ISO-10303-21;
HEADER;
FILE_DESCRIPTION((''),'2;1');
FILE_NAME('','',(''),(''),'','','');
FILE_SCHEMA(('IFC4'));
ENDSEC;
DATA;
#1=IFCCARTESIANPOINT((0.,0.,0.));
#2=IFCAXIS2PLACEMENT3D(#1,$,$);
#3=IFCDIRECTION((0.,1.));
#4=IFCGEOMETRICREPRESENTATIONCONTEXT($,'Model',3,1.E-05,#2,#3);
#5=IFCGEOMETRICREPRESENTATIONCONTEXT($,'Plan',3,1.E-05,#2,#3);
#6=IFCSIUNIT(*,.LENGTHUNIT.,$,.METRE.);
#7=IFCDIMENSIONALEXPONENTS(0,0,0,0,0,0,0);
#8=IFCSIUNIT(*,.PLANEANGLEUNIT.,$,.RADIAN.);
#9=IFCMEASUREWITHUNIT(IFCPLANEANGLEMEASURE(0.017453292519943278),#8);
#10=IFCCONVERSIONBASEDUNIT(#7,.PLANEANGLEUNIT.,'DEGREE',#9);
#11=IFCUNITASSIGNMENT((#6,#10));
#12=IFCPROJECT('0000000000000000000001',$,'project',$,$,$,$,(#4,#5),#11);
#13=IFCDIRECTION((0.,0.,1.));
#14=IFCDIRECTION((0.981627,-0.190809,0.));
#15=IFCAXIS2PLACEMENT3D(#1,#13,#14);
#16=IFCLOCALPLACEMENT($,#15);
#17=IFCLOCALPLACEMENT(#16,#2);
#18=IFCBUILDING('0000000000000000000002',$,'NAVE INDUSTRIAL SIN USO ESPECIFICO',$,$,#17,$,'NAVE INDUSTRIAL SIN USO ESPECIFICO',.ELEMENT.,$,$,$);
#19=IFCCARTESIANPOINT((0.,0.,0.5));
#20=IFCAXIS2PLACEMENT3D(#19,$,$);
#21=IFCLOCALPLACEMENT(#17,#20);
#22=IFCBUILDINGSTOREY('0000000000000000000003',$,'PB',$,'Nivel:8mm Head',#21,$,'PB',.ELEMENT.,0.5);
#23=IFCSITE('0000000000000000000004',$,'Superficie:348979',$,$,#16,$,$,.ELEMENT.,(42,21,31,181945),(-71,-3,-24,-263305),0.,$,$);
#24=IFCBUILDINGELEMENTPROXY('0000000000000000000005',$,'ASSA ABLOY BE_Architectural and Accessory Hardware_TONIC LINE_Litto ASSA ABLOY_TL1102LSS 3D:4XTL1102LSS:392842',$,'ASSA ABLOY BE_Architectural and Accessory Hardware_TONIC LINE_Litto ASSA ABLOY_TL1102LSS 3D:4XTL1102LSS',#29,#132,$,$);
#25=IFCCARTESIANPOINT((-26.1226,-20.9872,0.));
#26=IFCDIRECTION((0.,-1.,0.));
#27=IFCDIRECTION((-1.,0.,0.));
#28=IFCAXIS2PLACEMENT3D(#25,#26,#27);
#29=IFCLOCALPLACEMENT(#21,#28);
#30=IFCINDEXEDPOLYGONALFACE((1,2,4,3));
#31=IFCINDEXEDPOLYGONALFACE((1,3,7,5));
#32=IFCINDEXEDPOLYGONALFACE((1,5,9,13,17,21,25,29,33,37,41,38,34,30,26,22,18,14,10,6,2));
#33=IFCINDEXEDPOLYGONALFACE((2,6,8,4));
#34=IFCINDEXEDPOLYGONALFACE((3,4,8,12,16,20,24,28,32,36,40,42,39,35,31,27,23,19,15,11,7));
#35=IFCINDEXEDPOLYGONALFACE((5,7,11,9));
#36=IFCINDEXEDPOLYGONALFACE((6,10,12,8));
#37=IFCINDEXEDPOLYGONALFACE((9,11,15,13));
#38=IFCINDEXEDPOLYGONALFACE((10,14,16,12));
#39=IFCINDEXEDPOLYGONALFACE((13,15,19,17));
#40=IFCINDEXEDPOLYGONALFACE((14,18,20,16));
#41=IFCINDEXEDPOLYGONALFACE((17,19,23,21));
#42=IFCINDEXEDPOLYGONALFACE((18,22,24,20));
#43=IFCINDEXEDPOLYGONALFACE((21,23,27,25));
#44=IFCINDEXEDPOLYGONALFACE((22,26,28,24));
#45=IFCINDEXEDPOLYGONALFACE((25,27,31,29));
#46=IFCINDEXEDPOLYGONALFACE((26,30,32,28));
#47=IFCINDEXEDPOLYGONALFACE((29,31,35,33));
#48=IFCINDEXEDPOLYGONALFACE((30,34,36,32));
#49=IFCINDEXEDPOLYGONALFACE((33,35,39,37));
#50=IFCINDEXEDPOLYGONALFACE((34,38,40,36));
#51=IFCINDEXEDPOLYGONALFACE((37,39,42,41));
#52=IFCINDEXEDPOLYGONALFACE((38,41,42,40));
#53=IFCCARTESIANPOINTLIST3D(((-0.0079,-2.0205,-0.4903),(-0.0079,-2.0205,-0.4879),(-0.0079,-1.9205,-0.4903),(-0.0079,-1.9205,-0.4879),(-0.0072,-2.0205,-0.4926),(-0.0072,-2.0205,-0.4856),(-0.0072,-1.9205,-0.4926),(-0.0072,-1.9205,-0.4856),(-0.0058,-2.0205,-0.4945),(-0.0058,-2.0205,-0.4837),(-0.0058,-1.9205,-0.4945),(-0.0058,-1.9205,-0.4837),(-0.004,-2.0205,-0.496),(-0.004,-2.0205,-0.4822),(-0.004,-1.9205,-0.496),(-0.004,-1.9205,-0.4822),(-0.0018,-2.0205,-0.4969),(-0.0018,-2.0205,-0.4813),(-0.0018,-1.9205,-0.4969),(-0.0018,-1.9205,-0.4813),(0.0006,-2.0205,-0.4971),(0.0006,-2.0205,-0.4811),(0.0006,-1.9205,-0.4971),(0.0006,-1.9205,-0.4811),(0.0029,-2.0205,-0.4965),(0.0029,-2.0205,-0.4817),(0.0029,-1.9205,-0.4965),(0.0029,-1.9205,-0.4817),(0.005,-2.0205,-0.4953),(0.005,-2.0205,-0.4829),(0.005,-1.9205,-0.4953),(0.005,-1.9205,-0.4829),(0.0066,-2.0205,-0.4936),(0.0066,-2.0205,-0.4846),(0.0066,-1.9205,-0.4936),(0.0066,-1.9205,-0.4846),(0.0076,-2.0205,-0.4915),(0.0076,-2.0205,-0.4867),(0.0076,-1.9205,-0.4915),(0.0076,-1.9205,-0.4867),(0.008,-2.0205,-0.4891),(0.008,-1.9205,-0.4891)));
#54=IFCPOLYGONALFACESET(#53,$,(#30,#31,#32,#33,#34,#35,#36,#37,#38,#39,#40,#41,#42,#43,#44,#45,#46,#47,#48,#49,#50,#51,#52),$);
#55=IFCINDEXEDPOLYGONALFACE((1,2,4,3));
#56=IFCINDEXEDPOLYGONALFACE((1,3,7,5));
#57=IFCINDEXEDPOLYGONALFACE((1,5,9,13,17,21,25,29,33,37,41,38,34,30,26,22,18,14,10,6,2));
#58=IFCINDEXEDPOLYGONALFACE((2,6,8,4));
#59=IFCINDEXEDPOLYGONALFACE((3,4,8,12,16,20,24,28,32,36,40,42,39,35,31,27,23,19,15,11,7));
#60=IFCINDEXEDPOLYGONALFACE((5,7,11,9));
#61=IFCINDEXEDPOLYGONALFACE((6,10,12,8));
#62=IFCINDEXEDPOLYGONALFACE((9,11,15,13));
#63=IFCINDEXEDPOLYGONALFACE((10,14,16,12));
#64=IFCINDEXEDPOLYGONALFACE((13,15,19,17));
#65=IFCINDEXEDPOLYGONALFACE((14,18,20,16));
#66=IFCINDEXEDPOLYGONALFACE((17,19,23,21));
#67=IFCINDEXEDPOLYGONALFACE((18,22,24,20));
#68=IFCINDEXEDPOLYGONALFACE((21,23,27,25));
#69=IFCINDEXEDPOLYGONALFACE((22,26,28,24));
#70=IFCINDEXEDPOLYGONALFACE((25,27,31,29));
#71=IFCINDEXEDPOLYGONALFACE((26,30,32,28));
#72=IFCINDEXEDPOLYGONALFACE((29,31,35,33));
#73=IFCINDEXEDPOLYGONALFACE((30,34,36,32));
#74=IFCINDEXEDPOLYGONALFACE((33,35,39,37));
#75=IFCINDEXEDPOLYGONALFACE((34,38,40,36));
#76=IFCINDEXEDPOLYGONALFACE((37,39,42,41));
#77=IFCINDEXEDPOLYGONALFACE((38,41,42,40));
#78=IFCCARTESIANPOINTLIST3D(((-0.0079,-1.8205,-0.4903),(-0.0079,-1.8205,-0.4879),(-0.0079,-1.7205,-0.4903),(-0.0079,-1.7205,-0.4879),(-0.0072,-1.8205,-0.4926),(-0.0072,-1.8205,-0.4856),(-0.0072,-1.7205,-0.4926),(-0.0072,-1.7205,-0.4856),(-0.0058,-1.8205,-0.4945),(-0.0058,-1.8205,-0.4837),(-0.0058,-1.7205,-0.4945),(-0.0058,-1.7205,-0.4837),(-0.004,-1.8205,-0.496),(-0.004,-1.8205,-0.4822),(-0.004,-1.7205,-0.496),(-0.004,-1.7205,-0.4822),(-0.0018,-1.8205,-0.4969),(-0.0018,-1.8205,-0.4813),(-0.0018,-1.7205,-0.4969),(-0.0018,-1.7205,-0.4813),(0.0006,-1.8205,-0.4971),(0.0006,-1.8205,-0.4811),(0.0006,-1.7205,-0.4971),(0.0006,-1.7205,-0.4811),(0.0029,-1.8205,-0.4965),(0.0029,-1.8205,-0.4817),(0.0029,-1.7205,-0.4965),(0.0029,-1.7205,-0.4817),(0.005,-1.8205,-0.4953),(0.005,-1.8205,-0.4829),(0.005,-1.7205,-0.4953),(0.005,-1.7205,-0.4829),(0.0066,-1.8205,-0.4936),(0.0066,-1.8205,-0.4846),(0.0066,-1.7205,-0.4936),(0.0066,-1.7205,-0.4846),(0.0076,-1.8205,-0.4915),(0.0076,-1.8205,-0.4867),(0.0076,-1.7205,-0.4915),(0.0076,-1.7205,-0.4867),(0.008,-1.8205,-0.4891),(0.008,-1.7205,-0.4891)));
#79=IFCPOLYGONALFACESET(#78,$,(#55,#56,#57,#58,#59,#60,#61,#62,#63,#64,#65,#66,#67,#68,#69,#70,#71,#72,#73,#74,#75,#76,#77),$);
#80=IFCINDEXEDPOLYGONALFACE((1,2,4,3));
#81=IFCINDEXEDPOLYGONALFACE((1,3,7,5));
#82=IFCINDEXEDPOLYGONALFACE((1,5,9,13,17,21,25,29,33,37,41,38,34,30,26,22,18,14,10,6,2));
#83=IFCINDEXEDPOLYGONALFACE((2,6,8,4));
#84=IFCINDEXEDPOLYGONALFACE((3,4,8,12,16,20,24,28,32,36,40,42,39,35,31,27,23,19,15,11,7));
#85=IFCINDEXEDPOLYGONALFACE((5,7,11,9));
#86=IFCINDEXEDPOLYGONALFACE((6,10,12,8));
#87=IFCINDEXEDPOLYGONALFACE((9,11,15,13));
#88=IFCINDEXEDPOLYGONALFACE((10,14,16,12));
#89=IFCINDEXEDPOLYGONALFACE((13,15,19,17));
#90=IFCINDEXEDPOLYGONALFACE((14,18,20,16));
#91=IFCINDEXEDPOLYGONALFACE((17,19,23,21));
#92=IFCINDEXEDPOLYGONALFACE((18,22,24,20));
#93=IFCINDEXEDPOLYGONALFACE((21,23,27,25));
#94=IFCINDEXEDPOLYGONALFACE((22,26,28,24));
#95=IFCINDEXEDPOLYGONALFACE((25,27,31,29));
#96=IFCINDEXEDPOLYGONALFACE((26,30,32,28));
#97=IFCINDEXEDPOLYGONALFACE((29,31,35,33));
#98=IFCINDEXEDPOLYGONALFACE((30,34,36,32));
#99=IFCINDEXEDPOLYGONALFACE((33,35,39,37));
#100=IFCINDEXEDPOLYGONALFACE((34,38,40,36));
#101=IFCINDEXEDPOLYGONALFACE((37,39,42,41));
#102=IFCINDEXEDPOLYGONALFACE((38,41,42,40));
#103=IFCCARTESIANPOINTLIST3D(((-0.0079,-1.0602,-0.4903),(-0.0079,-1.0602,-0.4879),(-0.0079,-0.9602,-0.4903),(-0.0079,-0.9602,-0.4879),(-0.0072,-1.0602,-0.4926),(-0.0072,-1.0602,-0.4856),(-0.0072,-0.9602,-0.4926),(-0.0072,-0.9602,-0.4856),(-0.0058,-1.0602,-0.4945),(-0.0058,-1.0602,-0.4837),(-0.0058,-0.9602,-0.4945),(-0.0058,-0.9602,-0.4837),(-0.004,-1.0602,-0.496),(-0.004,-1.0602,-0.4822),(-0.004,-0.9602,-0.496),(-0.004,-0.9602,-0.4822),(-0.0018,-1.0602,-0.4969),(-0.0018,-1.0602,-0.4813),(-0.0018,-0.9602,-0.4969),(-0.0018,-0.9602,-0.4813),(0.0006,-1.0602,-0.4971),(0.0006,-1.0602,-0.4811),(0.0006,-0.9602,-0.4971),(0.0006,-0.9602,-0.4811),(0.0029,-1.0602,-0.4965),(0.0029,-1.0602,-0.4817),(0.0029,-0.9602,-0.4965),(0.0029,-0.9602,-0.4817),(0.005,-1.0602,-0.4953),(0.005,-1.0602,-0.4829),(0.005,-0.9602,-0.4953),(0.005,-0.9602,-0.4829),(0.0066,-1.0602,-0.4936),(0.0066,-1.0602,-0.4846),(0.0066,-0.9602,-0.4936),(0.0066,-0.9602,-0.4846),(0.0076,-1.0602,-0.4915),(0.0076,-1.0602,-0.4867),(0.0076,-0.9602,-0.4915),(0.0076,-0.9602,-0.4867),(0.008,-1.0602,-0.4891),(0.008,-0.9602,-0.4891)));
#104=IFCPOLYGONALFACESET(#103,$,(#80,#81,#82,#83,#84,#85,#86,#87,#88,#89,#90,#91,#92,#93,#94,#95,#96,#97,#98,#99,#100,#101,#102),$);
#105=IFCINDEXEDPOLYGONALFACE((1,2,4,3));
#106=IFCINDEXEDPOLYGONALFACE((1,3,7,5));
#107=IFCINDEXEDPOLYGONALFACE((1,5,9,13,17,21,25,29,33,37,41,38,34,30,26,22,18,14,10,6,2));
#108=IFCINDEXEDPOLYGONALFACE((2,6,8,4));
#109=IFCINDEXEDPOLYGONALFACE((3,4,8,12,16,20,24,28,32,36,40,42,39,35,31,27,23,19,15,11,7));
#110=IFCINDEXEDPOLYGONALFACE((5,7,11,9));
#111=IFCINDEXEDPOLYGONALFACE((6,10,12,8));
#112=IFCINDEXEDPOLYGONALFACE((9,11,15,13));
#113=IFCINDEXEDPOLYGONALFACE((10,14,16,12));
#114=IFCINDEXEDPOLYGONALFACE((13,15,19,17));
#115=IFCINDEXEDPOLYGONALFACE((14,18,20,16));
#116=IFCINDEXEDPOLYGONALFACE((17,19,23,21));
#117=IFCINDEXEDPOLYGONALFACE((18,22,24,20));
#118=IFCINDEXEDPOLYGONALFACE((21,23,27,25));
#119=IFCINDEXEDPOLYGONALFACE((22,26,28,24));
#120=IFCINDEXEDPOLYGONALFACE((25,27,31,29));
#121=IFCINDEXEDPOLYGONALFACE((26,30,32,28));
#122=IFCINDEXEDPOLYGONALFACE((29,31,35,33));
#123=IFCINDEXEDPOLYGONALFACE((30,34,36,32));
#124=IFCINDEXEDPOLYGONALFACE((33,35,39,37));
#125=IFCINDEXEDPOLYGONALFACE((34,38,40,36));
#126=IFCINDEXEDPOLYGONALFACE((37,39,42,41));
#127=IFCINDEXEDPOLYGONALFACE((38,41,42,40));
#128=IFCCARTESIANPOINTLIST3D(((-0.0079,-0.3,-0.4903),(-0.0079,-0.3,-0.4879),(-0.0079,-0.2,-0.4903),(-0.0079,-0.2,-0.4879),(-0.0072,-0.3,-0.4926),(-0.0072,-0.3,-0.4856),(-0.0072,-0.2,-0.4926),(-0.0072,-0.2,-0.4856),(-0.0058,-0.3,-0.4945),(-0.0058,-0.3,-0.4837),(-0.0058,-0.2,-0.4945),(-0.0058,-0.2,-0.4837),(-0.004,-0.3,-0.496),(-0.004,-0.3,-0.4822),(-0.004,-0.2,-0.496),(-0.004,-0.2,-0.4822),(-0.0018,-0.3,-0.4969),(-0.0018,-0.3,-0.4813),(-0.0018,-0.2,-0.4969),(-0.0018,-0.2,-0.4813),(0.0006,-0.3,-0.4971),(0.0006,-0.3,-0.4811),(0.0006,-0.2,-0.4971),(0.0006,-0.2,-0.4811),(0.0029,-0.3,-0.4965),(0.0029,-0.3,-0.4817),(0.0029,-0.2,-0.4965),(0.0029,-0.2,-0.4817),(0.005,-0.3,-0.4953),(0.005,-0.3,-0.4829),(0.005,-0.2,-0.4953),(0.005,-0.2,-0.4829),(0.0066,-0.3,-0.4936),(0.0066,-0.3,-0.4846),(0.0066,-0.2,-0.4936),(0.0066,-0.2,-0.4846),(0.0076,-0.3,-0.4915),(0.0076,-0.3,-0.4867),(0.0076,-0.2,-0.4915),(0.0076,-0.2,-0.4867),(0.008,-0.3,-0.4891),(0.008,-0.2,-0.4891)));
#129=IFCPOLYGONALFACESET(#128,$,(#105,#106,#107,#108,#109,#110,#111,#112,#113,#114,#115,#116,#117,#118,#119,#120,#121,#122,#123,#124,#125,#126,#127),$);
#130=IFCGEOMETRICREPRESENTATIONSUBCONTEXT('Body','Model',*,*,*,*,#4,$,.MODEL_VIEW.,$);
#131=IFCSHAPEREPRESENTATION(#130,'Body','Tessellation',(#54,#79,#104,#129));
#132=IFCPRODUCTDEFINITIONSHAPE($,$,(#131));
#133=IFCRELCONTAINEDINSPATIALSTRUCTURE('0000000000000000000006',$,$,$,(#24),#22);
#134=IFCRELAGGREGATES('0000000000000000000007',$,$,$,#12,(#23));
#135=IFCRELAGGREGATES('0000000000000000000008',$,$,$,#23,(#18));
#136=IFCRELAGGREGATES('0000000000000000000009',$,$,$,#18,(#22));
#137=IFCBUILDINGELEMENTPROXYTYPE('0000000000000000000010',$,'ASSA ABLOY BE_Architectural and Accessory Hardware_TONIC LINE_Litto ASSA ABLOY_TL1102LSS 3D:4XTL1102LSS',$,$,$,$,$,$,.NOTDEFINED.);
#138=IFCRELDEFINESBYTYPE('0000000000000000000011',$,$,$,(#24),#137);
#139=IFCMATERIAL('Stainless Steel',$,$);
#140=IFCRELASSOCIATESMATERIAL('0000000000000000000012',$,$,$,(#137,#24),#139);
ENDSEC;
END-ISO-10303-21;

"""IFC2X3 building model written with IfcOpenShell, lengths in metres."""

from ifc_helpers import new_model, entity, si_unit, converted_unit, direction, frame, frame_2d, origin, place, context, subcontext, project, spatial, circle, extrude, source, transform, mapped, material, type_object, type_shapes, element, save


model = new_model("IFC2X3")

# Units and contexts
model_context = context("Model", 3, precision=1e-05, world=origin(), true_north=direction((0.0, 1.0)))
plan_context = context("Plan", 3, precision=1e-05, world=origin(), true_north=direction((0.0, 1.0)))
body_context = subcontext(model_context, "Body", "Model", "MODEL_VIEW")
ifc_project = project(units=[si_unit("LENGTHUNIT", "METRE"), converted_unit("PLANEANGLEUNIT", "DEGREE", entity("IfcPlaneAngleMeasure", 0.017453292519943278), si_unit("PLANEANGLEUNIT", "RADIAN"), dimensions=[0, 0, 0, 0, 0, 0, 0])], contexts=[model_context, plan_context])

# Site, building, storey
site_placement = place(None, frame((0.0, 0.0, 0.0), z_axis=(0.0, 0.0, 1.0), x_axis=(0.981627, -0.190809, 0.0)))
site = spatial("IfcSite", under=ifc_project, at=site_placement, Name="Superficie:348979", CompositionType="ELEMENT", RefLatitude=(42, 21, 31, 181945), RefLongitude=(-71, -3, -24, -263305), RefElevation=0.0)
building_placement = place(site_placement, origin())
building = spatial("IfcBuilding", under=site, at=building_placement, Name="NAVE INDUSTRIAL SIN USO ESPECIFICO", LongName="NAVE INDUSTRIAL SIN USO ESPECIFICO", CompositionType="ELEMENT")
storey_placement = place(building_placement, frame((0.0, 0.0, 0.5)))
storey = spatial("IfcBuildingStorey", under=building, at=storey_placement, Name="PB", ObjectType="Nivel:8mm Head", LongName="PB", CompositionType="ELEMENT", Elevation=0.5)

# Building element proxy
ifc_material_1 = material(Name="Stainless Steel")
building_element_proxy_type_1 = type_object("IfcBuildingElementProxyType", Name="ASSA ABLOY BE_Architectural and Accessory Hardware_TONIC LINE_Litto ASSA ABLOY_TL1102LSS 3D:4XTL1102LSS", PredefinedType="NOTDEFINED", material=ifc_material_1)
shared_shape_1 = source(origin(), body_context, "Body", "SweptSolid", [
    extrude(circle(Radius=0.008, at=frame_2d((0.0, 0.0), x_axis=(1.0, 0.0))), frame((0.0, -2.0205, -0.4891), z_axis=(0.0, 1.0, 0.0), x_axis=(1.0, 0.0, 0.0)), (0.0, 0.0, 1.0), 0.1),
    extrude(circle(Radius=0.008, at=frame_2d((0.0, 0.0), x_axis=(1.0, 0.0))), frame((0.0, -1.8205, -0.4891), z_axis=(0.0, 1.0, 0.0), x_axis=(1.0, 0.0, 0.0)), (0.0, 0.0, 1.0), 0.1),
    extrude(circle(Radius=0.008, at=frame_2d((0.0, 0.0), x_axis=(1.0, 0.0))), frame((0.0, -1.0602, -0.4891), z_axis=(0.0, 1.0, 0.0), x_axis=(1.0, 0.0, 0.0)), (0.0, 0.0, 1.0), 0.1),
    extrude(circle(Radius=0.008, at=frame_2d((0.0, 0.0), x_axis=(1.0, 0.0))), frame((0.0, -0.3, -0.4891), z_axis=(0.0, 1.0, 0.0), x_axis=(1.0, 0.0, 0.0)), (0.0, 0.0, 1.0), 0.1),
])
type_shapes(building_element_proxy_type_1, [shared_shape_1])
for number, where, z_axis, x_axis, name in (
    (1, (-26.1226, -20.9872, 0.0), (0.0, -1.0, 0.0), (-1.0, 0.0, 0.0), "ASSA ABLOY BE_Architectural and Accessory Hardware_TONIC LINE_Litto ASSA ABLOY_TL1102LSS 3D:4XTL1102LSS:392842"),
):
    element("IfcBuildingElementProxy", number, at=place(storey_placement, frame(where, z_axis=z_axis, x_axis=x_axis)), inside=storey, type_object=building_element_proxy_type_1, material=ifc_material_1, Name=name, ObjectType="ASSA ABLOY BE_Architectural and Accessory Hardware_TONIC LINE_Litto ASSA ABLOY_TL1102LSS 3D:4XTL1102LSS", context=body_context, shape_type="MappedRepresentation", body=[
        mapped(shared_shape_1, transform((0.0, 0.0, 0.0), scale=1.0)),
    ])

save(model, "model.ifc")
